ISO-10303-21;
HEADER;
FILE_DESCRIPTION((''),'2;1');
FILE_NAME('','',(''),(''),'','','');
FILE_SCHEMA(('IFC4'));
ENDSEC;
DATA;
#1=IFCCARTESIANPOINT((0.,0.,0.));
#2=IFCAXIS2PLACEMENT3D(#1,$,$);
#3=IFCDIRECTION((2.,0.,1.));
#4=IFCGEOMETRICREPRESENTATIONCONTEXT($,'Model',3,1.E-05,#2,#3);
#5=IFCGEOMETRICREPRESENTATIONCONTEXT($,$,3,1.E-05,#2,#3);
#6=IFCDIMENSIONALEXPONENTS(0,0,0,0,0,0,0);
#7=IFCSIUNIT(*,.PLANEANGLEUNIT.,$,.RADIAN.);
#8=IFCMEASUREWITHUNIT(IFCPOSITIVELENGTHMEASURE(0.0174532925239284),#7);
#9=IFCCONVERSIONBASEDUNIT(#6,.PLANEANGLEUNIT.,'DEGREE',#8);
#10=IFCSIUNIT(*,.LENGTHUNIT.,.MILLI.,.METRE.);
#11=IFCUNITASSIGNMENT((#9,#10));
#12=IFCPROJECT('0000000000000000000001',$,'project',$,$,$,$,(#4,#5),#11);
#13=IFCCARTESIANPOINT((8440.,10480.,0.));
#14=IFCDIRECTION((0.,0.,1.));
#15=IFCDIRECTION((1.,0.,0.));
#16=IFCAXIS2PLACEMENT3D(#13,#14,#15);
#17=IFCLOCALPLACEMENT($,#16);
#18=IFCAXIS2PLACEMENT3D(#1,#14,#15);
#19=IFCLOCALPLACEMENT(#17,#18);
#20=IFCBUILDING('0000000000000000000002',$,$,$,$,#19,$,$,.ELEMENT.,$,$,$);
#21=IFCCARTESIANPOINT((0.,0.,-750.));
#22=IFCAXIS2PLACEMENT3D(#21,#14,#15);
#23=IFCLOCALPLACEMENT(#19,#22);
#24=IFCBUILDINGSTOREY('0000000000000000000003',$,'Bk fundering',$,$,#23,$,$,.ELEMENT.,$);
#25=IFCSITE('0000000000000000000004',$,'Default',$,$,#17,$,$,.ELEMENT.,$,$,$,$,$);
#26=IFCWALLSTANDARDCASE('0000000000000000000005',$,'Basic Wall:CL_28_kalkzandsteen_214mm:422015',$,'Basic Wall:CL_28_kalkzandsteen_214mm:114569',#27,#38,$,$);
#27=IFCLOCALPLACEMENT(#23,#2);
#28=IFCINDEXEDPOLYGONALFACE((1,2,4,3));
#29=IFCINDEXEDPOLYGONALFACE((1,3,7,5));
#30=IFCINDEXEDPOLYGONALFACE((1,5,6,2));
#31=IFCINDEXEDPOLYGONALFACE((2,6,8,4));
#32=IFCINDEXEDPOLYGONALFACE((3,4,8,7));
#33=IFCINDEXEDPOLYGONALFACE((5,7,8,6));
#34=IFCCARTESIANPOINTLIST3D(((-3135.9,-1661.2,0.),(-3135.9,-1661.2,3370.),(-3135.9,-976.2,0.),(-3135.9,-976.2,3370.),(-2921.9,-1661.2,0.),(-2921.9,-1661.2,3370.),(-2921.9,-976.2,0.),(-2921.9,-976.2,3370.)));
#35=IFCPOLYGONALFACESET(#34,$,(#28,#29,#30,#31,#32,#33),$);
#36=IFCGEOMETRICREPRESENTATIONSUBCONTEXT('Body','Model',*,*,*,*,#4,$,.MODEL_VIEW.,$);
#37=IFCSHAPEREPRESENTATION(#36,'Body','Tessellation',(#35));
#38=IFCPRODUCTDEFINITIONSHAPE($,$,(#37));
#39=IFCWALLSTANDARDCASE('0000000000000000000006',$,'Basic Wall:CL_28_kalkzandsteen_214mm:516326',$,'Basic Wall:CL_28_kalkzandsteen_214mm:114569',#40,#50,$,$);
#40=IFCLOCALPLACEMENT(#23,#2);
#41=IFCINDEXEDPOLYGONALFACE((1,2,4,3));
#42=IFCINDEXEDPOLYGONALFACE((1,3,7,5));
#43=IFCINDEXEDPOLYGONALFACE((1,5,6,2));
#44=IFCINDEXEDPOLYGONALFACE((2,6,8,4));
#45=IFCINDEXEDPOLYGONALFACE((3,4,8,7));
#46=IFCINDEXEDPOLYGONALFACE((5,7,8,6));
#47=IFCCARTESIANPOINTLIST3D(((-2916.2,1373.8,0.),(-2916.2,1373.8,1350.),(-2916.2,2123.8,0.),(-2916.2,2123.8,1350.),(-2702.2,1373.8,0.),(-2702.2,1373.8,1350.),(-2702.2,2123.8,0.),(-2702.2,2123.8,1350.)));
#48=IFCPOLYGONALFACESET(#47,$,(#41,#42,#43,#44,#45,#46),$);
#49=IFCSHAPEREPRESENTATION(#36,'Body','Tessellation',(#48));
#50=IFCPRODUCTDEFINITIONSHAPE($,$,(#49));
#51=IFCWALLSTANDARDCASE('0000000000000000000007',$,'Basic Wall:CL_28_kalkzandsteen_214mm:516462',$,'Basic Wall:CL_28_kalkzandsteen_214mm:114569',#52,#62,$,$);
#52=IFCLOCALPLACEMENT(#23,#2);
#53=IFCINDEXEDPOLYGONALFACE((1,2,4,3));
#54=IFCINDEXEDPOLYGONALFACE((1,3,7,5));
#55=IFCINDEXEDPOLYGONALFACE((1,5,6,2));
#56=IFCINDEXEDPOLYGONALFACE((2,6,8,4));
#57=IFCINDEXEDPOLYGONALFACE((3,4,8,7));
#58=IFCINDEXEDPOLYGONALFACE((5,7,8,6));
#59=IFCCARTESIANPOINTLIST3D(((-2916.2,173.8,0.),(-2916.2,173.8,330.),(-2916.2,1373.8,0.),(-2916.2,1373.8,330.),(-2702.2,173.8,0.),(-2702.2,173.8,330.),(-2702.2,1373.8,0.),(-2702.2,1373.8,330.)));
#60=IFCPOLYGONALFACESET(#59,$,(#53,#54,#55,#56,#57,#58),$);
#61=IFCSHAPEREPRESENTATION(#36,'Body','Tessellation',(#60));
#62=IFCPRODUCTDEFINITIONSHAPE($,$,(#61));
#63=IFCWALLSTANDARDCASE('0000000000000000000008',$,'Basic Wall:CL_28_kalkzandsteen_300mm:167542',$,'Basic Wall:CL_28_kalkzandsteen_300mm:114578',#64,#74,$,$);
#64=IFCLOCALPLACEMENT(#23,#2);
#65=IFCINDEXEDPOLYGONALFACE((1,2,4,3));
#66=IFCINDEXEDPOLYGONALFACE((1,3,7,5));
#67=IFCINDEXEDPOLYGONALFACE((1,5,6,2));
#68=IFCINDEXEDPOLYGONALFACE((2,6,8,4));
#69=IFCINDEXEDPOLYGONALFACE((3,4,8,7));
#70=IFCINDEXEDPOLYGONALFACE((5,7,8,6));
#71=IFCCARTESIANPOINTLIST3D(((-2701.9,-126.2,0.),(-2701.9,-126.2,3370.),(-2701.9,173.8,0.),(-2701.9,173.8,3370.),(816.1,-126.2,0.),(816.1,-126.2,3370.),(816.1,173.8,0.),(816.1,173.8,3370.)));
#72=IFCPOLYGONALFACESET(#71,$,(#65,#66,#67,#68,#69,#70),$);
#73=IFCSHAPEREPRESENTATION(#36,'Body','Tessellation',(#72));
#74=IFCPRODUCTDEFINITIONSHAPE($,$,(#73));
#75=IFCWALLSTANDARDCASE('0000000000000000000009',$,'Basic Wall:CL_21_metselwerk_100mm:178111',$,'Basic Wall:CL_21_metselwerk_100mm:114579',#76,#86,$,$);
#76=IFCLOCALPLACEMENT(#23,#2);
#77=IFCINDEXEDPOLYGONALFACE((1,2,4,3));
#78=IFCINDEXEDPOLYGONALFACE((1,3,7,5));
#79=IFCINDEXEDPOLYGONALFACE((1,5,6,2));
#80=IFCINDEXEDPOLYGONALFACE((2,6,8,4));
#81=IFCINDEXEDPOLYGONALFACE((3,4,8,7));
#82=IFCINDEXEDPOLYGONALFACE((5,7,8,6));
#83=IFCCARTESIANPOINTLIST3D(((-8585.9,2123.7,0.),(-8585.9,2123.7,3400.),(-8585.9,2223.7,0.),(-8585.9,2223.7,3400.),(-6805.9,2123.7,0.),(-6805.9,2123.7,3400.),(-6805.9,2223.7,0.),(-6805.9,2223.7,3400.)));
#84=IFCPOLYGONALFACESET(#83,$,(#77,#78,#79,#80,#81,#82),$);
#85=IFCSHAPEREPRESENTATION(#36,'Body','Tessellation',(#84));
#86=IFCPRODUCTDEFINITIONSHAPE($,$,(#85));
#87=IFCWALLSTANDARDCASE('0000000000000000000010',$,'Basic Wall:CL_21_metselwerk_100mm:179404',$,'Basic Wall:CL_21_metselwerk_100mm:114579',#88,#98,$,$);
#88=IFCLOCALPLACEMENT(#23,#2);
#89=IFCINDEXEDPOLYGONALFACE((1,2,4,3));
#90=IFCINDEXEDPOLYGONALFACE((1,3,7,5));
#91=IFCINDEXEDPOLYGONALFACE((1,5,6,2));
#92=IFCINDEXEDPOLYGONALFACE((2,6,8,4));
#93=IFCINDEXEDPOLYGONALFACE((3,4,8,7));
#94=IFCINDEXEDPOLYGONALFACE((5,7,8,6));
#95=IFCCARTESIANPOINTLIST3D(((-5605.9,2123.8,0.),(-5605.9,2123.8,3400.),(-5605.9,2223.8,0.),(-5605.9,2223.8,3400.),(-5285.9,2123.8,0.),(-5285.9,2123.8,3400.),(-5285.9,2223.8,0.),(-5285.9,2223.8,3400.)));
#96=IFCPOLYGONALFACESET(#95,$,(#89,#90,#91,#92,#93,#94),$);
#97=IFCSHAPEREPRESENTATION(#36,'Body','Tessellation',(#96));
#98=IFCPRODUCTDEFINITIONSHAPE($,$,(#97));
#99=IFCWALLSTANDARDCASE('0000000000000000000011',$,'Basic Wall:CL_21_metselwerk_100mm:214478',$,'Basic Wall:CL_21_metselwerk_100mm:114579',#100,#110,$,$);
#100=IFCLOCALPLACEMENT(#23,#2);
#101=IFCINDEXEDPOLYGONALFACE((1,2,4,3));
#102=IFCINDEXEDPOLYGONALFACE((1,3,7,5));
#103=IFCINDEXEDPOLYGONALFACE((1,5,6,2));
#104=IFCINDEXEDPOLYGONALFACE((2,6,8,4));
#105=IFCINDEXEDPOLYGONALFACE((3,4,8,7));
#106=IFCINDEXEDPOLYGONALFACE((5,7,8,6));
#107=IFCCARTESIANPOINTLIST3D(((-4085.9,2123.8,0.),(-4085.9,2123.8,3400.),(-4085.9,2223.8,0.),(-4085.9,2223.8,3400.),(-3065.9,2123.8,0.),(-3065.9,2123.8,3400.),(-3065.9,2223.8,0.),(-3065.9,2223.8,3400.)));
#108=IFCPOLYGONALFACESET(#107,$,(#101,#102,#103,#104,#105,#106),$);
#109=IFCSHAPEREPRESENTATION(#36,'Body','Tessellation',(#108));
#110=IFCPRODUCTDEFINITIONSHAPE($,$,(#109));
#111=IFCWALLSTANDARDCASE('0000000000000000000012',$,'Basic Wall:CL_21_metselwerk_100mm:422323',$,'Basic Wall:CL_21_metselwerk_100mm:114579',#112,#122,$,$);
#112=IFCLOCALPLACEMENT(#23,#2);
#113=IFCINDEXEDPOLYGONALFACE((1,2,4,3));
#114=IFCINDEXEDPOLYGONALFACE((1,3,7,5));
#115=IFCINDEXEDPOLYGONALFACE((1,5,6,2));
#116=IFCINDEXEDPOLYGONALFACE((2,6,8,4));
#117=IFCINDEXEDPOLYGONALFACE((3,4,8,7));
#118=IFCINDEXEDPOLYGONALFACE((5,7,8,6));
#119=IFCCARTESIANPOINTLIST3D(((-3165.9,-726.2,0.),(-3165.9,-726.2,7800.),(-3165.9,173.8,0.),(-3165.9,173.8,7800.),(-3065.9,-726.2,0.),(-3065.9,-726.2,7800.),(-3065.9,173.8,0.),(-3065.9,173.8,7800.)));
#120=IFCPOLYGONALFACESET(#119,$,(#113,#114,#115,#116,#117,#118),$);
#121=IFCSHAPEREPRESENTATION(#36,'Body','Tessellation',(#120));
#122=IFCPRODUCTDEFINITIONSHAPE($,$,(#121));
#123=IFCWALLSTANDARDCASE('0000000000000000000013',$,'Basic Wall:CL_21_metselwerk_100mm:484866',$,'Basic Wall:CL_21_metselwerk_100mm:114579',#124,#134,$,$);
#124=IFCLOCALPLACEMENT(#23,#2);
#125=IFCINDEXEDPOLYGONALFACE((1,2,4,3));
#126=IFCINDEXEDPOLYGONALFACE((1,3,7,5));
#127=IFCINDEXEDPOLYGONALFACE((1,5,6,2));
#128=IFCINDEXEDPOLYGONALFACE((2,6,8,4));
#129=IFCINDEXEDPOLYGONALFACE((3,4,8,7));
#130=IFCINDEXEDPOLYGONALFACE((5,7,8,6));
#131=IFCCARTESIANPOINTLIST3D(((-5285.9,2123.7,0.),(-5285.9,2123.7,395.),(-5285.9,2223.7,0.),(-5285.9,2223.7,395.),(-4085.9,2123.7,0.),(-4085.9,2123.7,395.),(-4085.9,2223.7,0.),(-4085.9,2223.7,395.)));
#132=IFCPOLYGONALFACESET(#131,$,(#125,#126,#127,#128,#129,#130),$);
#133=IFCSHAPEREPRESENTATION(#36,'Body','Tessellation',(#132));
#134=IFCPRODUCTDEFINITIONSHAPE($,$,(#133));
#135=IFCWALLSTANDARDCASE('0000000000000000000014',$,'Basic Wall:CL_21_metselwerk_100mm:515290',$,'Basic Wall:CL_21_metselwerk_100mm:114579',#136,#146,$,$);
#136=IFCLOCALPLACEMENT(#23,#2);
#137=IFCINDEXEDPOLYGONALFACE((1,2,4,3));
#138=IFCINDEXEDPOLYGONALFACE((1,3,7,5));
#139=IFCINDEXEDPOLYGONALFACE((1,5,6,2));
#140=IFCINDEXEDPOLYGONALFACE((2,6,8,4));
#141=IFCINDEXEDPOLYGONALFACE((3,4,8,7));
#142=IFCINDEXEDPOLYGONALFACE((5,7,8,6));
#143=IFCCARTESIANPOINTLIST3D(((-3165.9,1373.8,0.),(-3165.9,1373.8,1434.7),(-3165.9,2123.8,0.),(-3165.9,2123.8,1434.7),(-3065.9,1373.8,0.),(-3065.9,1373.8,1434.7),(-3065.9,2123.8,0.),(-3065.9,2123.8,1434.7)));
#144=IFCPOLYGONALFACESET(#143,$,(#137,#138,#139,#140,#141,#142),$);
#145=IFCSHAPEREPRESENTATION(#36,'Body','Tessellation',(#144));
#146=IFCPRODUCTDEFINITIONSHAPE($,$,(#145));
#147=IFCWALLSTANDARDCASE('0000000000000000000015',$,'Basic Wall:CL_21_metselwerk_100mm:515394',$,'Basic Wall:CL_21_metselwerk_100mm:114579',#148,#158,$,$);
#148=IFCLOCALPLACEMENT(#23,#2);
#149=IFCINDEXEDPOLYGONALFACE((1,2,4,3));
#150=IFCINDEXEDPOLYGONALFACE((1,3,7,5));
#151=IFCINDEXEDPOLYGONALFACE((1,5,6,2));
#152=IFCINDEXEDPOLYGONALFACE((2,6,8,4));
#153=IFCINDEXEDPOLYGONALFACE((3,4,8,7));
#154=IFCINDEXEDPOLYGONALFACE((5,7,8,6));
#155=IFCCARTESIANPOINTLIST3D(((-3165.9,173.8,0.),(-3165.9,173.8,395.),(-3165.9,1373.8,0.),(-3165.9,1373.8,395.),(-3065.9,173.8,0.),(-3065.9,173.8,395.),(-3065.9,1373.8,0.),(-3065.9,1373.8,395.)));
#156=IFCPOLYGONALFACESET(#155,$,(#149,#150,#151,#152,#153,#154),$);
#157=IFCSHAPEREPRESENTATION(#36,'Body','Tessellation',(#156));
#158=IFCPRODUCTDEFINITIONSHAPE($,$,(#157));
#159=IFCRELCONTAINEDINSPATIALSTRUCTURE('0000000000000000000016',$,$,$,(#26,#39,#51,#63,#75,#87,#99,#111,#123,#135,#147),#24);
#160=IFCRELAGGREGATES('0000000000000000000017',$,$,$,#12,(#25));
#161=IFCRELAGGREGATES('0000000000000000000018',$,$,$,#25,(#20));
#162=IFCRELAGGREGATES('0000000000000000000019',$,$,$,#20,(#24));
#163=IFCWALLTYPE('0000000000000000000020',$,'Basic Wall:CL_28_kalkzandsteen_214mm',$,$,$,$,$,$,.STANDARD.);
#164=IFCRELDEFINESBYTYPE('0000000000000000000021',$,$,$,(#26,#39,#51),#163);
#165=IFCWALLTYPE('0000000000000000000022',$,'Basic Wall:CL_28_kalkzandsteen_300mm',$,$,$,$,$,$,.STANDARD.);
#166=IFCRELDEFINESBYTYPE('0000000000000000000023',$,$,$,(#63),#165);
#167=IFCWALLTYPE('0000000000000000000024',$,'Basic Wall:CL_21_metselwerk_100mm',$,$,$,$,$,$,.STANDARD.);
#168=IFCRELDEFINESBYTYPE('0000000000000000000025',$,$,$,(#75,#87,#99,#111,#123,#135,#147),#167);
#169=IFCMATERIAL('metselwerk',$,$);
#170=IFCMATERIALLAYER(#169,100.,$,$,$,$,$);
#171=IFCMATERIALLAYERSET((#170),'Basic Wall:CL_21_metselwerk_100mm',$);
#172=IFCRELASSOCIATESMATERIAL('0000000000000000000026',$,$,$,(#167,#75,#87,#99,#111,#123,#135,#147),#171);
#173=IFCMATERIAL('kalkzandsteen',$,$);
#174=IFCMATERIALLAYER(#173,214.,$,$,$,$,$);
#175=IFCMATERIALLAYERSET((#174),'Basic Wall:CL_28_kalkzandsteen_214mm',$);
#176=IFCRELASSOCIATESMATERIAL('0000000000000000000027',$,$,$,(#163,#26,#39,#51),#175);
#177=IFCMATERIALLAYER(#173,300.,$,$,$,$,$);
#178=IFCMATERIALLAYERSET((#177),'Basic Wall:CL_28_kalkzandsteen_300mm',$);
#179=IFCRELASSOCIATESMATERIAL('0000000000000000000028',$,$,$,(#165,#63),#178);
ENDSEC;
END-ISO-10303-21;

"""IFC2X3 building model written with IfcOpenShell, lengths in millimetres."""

from ifc_helpers import new_model, entity, si_unit, converted_unit, direction, frame, frame_2d, origin, origin_with_axes, place, context, subcontext, project, spatial, polyline, rectangle, extrude, clip, halfspace, bounded_halfspace, material, layer, layer_set, layer_usage, type_object, element, save


model = new_model("IFC2X3")

# Units and contexts
model_context = context("Model", 3, precision=1e-05, world=origin(), true_north=direction((2.0, 0.0, 1.0)))
context_of_model = context(None, 3, precision=1e-05, world=origin(), true_north=direction((2.0, 0.0, 1.0)))
body_context = subcontext(model_context, "Body", "Model", "MODEL_VIEW")
ifc_project = project(units=[converted_unit("PLANEANGLEUNIT", "DEGREE", entity("IfcPositiveLengthMeasure", 0.0174532925239284), si_unit("PLANEANGLEUNIT", "RADIAN"), dimensions=[0, 0, 0, 0, 0, 0, 0]), si_unit("LENGTHUNIT", "METRE", prefix="MILLI")], contexts=[model_context, context_of_model])

# Site, building, storey
site_placement = place(None, frame((8440.0, 10480.0, 0.0), z_axis=(0.0, 0.0, 1.0), x_axis=(1.0, 0.0, 0.0)))
site = spatial("IfcSite", under=ifc_project, at=site_placement, Name="Default", CompositionType="ELEMENT")
building_placement = place(site_placement, origin_with_axes())
building = spatial("IfcBuilding", under=site, at=building_placement, CompositionType="ELEMENT")
storey_placement = place(building_placement, frame((0.0, 0.0, -750.0), z_axis=(0.0, 0.0, 1.0), x_axis=(1.0, 0.0, 0.0)))
storey = spatial("IfcBuildingStorey", under=building, at=storey_placement, Name="Bk fundering", CompositionType="ELEMENT")

# Walls
ifc_material_1 = material(Name="metselwerk")
ifc_layer_1 = layer(ifc_material_1, 100.0)
ifc_layer_set_1 = layer_set([ifc_layer_1], Name="Basic Wall:CL_21_metselwerk_100mm")
wall_type_1 = type_object("IfcWallType", Name="Basic Wall:CL_21_metselwerk_100mm", PredefinedType="STANDARD", material=ifc_layer_set_1)
ifc_material_2 = material(Name="kalkzandsteen")
ifc_layer_2 = layer(ifc_material_2, 214.0)
ifc_layer_set_2 = layer_set([ifc_layer_2], Name="Basic Wall:CL_28_kalkzandsteen_214mm")
wall_type_2 = type_object("IfcWallType", Name="Basic Wall:CL_28_kalkzandsteen_214mm", PredefinedType="STANDARD", material=ifc_layer_set_2)
ifc_layer_usage_1 = layer_usage(ifc_layer_set_2, "AXIS2", "NEGATIVE", 107.0)
wall_1_placement = place(storey_placement, frame((-3028.9, -976.2, 0.0), z_axis=(0.0, 0.0, 1.0), x_axis=(0.0, -1.0, 0.0)))
element("IfcWallStandardCase", 1, at=wall_1_placement, inside=storey, type_object=wall_type_2, material=ifc_layer_usage_1, Name="Basic Wall:CL_28_kalkzandsteen_214mm:422015", ObjectType="Basic Wall:CL_28_kalkzandsteen_214mm:114569", context=body_context, shape_type="Clipping", body=[
    clip(extrude(rectangle(XDim=685.0, YDim=214.0, at=frame_2d((342.5, 0.0), x_axis=(-1.0, 0.0))), origin(), (0.0, 0.0, 1.0), 3370.0), bounded_halfspace(frame((0.0, -107.0, 3370.0), z_axis=(0.0, 0.0, -1.0), x_axis=(0.0, 1.0, 0.0)), True, frame((0.0, -107.0, 3370.0)), polyline([(0.0, 0.0), (685.0, 0.0), (685.0, 214.0), (0.0, 214.0), (0.0, 0.0)]))),
])
ifc_layer_usage_2 = layer_usage(ifc_layer_set_2, "AXIS2", "NEGATIVE", 107.0)
wall_2_placement = place(storey_placement, frame((-2809.2, 1373.8, 0.0), z_axis=(0.0, 0.0, 1.0), x_axis=(0.0, 1.0, 0.0)))
element("IfcWallStandardCase", 2, at=wall_2_placement, inside=storey, type_object=wall_type_2, material=ifc_layer_usage_2, Name="Basic Wall:CL_28_kalkzandsteen_214mm:516326", ObjectType="Basic Wall:CL_28_kalkzandsteen_214mm:114569", context=body_context, shape_type="SweptSolid", body=[
    extrude(rectangle(XDim=750.0, YDim=214.0, at=frame_2d((375.0, 0.0), x_axis=(-1.0, 0.0))), origin(), (0.0, 0.0, 1.0), 1350.0),
])
ifc_layer_usage_3 = layer_usage(ifc_layer_set_2, "AXIS2", "NEGATIVE", 107.0)
wall_3_placement = place(storey_placement, frame((-2809.2, 173.8, 0.0), z_axis=(0.0, 0.0, 1.0), x_axis=(0.0, 1.0, 0.0)))
element("IfcWallStandardCase", 3, at=wall_3_placement, inside=storey, type_object=wall_type_2, material=ifc_layer_usage_3, Name="Basic Wall:CL_28_kalkzandsteen_214mm:516462", ObjectType="Basic Wall:CL_28_kalkzandsteen_214mm:114569", context=body_context, shape_type="SweptSolid", body=[
    extrude(rectangle(XDim=1200.0, YDim=214.0, at=frame_2d((600.0, 0.0), x_axis=(-1.0, 0.0))), origin(), (0.0, 0.0, 1.0), 330.0),
])
ifc_layer_3 = layer(ifc_material_2, 300.0)
ifc_layer_set_3 = layer_set([ifc_layer_3], Name="Basic Wall:CL_28_kalkzandsteen_300mm")
ifc_layer_usage_4 = layer_usage(ifc_layer_set_3, "AXIS2", "NEGATIVE", 150.0)
wall_type_3 = type_object("IfcWallType", Name="Basic Wall:CL_28_kalkzandsteen_300mm", PredefinedType="STANDARD", material=ifc_layer_set_3)
wall_4_placement = place(storey_placement, frame((-2701.9, 23.8, 0.0), z_axis=(0.0, 0.0, 1.0), x_axis=(1.0, 0.0, 0.0)))
element("IfcWallStandardCase", 4, at=wall_4_placement, inside=storey, type_object=wall_type_3, material=ifc_layer_usage_4, Name="Basic Wall:CL_28_kalkzandsteen_300mm:167542", ObjectType="Basic Wall:CL_28_kalkzandsteen_300mm:114578", context=body_context, shape_type="Clipping", body=[
    clip(extrude(rectangle(XDim=3518.0, YDim=300.0, at=frame_2d((1759.0, 0.0), x_axis=(-1.0, 0.0))), origin(), (0.0, 0.0, 1.0), 3370.0), bounded_halfspace(frame((0.0, -150.0, 3370.0), z_axis=(0.0, 0.0, -1.0), x_axis=(1.0, 0.0, 0.0)), True, frame((0.0, -150.0, 3370.0)), polyline([(0.0, 0.0), (3518.0, 0.0), (3518.0, 300.0), (0.0, 300.0), (0.0, 0.0)]))),
])
ifc_layer_usage_5 = layer_usage(ifc_layer_set_1, "AXIS2", "NEGATIVE", 50.0)
wall_5_placement = place(storey_placement, frame((-8585.9, 2173.7, 0.0), z_axis=(0.0, 0.0, 1.0), x_axis=(1.0, 0.0, 0.0)))
element("IfcWallStandardCase", 5, at=wall_5_placement, inside=storey, type_object=wall_type_1, material=ifc_layer_usage_5, Name="Basic Wall:CL_21_metselwerk_100mm:178111", ObjectType="Basic Wall:CL_21_metselwerk_100mm:114579", context=body_context, shape_type="SweptSolid", body=[
    extrude(rectangle(XDim=1780.0, YDim=100.0, at=frame_2d((890.0, 0.0), x_axis=(-1.0, 0.0))), origin(), (0.0, 0.0, 1.0), 3400.0),
])
ifc_layer_usage_6 = layer_usage(ifc_layer_set_1, "AXIS2", "NEGATIVE", 50.0)
wall_6_placement = place(storey_placement, frame((-5605.9, 2173.8, 0.0), z_axis=(0.0, 0.0, 1.0), x_axis=(1.0, 0.0, 0.0)))
element("IfcWallStandardCase", 6, at=wall_6_placement, inside=storey, type_object=wall_type_1, material=ifc_layer_usage_6, Name="Basic Wall:CL_21_metselwerk_100mm:179404", ObjectType="Basic Wall:CL_21_metselwerk_100mm:114579", context=body_context, shape_type="SweptSolid", body=[
    extrude(rectangle(XDim=320.0, YDim=100.0, at=frame_2d((160.0, 0.0), x_axis=(-1.0, 0.0))), origin(), (0.0, 0.0, 1.0), 3400.0),
])
ifc_layer_usage_7 = layer_usage(ifc_layer_set_1, "AXIS2", "NEGATIVE", 50.0)
wall_7_placement = place(storey_placement, frame((-4085.9, 2173.8, 0.0), z_axis=(0.0, 0.0, 1.0), x_axis=(1.0, 0.0, 0.0)))
element("IfcWallStandardCase", 7, at=wall_7_placement, inside=storey, type_object=wall_type_1, material=ifc_layer_usage_7, Name="Basic Wall:CL_21_metselwerk_100mm:214478", ObjectType="Basic Wall:CL_21_metselwerk_100mm:114579", context=body_context, shape_type="SweptSolid", body=[
    extrude(rectangle(XDim=1020.0, YDim=100.0, at=frame_2d((510.0, 0.0), x_axis=(-1.0, 0.0))), origin(), (0.0, 0.0, 1.0), 3400.0),
])
ifc_layer_usage_8 = layer_usage(ifc_layer_set_1, "AXIS2", "NEGATIVE", 50.0)
wall_8_placement = place(storey_placement, frame((-3115.9, 173.8, 0.0), z_axis=(0.0, 0.0, 1.0), x_axis=(0.0, -1.0, 0.0)))
element("IfcWallStandardCase", 8, at=wall_8_placement, inside=storey, type_object=wall_type_1, material=ifc_layer_usage_8, Name="Basic Wall:CL_21_metselwerk_100mm:422323", ObjectType="Basic Wall:CL_21_metselwerk_100mm:114579", context=body_context, shape_type="SweptSolid", body=[
    extrude(rectangle(XDim=900.0, YDim=100.0, at=frame_2d((450.0, 0.0), x_axis=(-1.0, 0.0))), origin(), (0.0, 0.0, 1.0), 7800.0),
])
ifc_layer_usage_9 = layer_usage(ifc_layer_set_1, "AXIS2", "NEGATIVE", 50.0)
wall_9_placement = place(storey_placement, frame((-5285.9, 2173.7, 0.0), z_axis=(0.0, 0.0, 1.0), x_axis=(1.0, 0.0, 0.0)))
element("IfcWallStandardCase", 9, at=wall_9_placement, inside=storey, type_object=wall_type_1, material=ifc_layer_usage_9, Name="Basic Wall:CL_21_metselwerk_100mm:484866", ObjectType="Basic Wall:CL_21_metselwerk_100mm:114579", context=body_context, shape_type="Clipping", body=[
    clip(extrude(rectangle(XDim=1200.0, YDim=100.0, at=frame_2d((600.0, 0.0), x_axis=(-1.0, 0.0))), origin(), (0.0, 0.0, 1.0), 1250.0), halfspace(frame((0.0, -50.0, 395.0), z_axis=(0.0, 0.0, 1.0), x_axis=(0.0, 1.0, 0.0)), False)),
])
ifc_layer_usage_10 = layer_usage(ifc_layer_set_1, "AXIS2", "NEGATIVE", 50.0)
wall_10_placement = place(storey_placement, frame((-3115.9, 2123.8, 0.0), z_axis=(0.0, 0.0, 1.0), x_axis=(0.0, -1.0, 0.0)))
element("IfcWallStandardCase", 10, at=wall_10_placement, inside=storey, type_object=wall_type_1, material=ifc_layer_usage_10, Name="Basic Wall:CL_21_metselwerk_100mm:515290", ObjectType="Basic Wall:CL_21_metselwerk_100mm:114579", context=body_context, shape_type="SweptSolid", body=[
    extrude(rectangle(XDim=750.0, YDim=100.0, at=frame_2d((375.0, 0.0), x_axis=(-1.0, 0.0))), origin(), (0.0, 0.0, 1.0), 1434.7),
])
ifc_layer_usage_11 = layer_usage(ifc_layer_set_1, "AXIS2", "NEGATIVE", 50.0)
wall_11_placement = place(storey_placement, frame((-3115.9, 1373.8, 0.0), z_axis=(0.0, 0.0, 1.0), x_axis=(0.0, -1.0, 0.0)))
element("IfcWallStandardCase", 11, at=wall_11_placement, inside=storey, type_object=wall_type_1, material=ifc_layer_usage_11, Name="Basic Wall:CL_21_metselwerk_100mm:515394", ObjectType="Basic Wall:CL_21_metselwerk_100mm:114579", context=body_context, shape_type="SweptSolid", body=[
    extrude(rectangle(XDim=1200.0, YDim=100.0, at=frame_2d((600.0, 0.0), x_axis=(-1.0, 0.0))), origin(), (0.0, 0.0, 1.0), 395.0),
])

save(model, "model.ifc")
